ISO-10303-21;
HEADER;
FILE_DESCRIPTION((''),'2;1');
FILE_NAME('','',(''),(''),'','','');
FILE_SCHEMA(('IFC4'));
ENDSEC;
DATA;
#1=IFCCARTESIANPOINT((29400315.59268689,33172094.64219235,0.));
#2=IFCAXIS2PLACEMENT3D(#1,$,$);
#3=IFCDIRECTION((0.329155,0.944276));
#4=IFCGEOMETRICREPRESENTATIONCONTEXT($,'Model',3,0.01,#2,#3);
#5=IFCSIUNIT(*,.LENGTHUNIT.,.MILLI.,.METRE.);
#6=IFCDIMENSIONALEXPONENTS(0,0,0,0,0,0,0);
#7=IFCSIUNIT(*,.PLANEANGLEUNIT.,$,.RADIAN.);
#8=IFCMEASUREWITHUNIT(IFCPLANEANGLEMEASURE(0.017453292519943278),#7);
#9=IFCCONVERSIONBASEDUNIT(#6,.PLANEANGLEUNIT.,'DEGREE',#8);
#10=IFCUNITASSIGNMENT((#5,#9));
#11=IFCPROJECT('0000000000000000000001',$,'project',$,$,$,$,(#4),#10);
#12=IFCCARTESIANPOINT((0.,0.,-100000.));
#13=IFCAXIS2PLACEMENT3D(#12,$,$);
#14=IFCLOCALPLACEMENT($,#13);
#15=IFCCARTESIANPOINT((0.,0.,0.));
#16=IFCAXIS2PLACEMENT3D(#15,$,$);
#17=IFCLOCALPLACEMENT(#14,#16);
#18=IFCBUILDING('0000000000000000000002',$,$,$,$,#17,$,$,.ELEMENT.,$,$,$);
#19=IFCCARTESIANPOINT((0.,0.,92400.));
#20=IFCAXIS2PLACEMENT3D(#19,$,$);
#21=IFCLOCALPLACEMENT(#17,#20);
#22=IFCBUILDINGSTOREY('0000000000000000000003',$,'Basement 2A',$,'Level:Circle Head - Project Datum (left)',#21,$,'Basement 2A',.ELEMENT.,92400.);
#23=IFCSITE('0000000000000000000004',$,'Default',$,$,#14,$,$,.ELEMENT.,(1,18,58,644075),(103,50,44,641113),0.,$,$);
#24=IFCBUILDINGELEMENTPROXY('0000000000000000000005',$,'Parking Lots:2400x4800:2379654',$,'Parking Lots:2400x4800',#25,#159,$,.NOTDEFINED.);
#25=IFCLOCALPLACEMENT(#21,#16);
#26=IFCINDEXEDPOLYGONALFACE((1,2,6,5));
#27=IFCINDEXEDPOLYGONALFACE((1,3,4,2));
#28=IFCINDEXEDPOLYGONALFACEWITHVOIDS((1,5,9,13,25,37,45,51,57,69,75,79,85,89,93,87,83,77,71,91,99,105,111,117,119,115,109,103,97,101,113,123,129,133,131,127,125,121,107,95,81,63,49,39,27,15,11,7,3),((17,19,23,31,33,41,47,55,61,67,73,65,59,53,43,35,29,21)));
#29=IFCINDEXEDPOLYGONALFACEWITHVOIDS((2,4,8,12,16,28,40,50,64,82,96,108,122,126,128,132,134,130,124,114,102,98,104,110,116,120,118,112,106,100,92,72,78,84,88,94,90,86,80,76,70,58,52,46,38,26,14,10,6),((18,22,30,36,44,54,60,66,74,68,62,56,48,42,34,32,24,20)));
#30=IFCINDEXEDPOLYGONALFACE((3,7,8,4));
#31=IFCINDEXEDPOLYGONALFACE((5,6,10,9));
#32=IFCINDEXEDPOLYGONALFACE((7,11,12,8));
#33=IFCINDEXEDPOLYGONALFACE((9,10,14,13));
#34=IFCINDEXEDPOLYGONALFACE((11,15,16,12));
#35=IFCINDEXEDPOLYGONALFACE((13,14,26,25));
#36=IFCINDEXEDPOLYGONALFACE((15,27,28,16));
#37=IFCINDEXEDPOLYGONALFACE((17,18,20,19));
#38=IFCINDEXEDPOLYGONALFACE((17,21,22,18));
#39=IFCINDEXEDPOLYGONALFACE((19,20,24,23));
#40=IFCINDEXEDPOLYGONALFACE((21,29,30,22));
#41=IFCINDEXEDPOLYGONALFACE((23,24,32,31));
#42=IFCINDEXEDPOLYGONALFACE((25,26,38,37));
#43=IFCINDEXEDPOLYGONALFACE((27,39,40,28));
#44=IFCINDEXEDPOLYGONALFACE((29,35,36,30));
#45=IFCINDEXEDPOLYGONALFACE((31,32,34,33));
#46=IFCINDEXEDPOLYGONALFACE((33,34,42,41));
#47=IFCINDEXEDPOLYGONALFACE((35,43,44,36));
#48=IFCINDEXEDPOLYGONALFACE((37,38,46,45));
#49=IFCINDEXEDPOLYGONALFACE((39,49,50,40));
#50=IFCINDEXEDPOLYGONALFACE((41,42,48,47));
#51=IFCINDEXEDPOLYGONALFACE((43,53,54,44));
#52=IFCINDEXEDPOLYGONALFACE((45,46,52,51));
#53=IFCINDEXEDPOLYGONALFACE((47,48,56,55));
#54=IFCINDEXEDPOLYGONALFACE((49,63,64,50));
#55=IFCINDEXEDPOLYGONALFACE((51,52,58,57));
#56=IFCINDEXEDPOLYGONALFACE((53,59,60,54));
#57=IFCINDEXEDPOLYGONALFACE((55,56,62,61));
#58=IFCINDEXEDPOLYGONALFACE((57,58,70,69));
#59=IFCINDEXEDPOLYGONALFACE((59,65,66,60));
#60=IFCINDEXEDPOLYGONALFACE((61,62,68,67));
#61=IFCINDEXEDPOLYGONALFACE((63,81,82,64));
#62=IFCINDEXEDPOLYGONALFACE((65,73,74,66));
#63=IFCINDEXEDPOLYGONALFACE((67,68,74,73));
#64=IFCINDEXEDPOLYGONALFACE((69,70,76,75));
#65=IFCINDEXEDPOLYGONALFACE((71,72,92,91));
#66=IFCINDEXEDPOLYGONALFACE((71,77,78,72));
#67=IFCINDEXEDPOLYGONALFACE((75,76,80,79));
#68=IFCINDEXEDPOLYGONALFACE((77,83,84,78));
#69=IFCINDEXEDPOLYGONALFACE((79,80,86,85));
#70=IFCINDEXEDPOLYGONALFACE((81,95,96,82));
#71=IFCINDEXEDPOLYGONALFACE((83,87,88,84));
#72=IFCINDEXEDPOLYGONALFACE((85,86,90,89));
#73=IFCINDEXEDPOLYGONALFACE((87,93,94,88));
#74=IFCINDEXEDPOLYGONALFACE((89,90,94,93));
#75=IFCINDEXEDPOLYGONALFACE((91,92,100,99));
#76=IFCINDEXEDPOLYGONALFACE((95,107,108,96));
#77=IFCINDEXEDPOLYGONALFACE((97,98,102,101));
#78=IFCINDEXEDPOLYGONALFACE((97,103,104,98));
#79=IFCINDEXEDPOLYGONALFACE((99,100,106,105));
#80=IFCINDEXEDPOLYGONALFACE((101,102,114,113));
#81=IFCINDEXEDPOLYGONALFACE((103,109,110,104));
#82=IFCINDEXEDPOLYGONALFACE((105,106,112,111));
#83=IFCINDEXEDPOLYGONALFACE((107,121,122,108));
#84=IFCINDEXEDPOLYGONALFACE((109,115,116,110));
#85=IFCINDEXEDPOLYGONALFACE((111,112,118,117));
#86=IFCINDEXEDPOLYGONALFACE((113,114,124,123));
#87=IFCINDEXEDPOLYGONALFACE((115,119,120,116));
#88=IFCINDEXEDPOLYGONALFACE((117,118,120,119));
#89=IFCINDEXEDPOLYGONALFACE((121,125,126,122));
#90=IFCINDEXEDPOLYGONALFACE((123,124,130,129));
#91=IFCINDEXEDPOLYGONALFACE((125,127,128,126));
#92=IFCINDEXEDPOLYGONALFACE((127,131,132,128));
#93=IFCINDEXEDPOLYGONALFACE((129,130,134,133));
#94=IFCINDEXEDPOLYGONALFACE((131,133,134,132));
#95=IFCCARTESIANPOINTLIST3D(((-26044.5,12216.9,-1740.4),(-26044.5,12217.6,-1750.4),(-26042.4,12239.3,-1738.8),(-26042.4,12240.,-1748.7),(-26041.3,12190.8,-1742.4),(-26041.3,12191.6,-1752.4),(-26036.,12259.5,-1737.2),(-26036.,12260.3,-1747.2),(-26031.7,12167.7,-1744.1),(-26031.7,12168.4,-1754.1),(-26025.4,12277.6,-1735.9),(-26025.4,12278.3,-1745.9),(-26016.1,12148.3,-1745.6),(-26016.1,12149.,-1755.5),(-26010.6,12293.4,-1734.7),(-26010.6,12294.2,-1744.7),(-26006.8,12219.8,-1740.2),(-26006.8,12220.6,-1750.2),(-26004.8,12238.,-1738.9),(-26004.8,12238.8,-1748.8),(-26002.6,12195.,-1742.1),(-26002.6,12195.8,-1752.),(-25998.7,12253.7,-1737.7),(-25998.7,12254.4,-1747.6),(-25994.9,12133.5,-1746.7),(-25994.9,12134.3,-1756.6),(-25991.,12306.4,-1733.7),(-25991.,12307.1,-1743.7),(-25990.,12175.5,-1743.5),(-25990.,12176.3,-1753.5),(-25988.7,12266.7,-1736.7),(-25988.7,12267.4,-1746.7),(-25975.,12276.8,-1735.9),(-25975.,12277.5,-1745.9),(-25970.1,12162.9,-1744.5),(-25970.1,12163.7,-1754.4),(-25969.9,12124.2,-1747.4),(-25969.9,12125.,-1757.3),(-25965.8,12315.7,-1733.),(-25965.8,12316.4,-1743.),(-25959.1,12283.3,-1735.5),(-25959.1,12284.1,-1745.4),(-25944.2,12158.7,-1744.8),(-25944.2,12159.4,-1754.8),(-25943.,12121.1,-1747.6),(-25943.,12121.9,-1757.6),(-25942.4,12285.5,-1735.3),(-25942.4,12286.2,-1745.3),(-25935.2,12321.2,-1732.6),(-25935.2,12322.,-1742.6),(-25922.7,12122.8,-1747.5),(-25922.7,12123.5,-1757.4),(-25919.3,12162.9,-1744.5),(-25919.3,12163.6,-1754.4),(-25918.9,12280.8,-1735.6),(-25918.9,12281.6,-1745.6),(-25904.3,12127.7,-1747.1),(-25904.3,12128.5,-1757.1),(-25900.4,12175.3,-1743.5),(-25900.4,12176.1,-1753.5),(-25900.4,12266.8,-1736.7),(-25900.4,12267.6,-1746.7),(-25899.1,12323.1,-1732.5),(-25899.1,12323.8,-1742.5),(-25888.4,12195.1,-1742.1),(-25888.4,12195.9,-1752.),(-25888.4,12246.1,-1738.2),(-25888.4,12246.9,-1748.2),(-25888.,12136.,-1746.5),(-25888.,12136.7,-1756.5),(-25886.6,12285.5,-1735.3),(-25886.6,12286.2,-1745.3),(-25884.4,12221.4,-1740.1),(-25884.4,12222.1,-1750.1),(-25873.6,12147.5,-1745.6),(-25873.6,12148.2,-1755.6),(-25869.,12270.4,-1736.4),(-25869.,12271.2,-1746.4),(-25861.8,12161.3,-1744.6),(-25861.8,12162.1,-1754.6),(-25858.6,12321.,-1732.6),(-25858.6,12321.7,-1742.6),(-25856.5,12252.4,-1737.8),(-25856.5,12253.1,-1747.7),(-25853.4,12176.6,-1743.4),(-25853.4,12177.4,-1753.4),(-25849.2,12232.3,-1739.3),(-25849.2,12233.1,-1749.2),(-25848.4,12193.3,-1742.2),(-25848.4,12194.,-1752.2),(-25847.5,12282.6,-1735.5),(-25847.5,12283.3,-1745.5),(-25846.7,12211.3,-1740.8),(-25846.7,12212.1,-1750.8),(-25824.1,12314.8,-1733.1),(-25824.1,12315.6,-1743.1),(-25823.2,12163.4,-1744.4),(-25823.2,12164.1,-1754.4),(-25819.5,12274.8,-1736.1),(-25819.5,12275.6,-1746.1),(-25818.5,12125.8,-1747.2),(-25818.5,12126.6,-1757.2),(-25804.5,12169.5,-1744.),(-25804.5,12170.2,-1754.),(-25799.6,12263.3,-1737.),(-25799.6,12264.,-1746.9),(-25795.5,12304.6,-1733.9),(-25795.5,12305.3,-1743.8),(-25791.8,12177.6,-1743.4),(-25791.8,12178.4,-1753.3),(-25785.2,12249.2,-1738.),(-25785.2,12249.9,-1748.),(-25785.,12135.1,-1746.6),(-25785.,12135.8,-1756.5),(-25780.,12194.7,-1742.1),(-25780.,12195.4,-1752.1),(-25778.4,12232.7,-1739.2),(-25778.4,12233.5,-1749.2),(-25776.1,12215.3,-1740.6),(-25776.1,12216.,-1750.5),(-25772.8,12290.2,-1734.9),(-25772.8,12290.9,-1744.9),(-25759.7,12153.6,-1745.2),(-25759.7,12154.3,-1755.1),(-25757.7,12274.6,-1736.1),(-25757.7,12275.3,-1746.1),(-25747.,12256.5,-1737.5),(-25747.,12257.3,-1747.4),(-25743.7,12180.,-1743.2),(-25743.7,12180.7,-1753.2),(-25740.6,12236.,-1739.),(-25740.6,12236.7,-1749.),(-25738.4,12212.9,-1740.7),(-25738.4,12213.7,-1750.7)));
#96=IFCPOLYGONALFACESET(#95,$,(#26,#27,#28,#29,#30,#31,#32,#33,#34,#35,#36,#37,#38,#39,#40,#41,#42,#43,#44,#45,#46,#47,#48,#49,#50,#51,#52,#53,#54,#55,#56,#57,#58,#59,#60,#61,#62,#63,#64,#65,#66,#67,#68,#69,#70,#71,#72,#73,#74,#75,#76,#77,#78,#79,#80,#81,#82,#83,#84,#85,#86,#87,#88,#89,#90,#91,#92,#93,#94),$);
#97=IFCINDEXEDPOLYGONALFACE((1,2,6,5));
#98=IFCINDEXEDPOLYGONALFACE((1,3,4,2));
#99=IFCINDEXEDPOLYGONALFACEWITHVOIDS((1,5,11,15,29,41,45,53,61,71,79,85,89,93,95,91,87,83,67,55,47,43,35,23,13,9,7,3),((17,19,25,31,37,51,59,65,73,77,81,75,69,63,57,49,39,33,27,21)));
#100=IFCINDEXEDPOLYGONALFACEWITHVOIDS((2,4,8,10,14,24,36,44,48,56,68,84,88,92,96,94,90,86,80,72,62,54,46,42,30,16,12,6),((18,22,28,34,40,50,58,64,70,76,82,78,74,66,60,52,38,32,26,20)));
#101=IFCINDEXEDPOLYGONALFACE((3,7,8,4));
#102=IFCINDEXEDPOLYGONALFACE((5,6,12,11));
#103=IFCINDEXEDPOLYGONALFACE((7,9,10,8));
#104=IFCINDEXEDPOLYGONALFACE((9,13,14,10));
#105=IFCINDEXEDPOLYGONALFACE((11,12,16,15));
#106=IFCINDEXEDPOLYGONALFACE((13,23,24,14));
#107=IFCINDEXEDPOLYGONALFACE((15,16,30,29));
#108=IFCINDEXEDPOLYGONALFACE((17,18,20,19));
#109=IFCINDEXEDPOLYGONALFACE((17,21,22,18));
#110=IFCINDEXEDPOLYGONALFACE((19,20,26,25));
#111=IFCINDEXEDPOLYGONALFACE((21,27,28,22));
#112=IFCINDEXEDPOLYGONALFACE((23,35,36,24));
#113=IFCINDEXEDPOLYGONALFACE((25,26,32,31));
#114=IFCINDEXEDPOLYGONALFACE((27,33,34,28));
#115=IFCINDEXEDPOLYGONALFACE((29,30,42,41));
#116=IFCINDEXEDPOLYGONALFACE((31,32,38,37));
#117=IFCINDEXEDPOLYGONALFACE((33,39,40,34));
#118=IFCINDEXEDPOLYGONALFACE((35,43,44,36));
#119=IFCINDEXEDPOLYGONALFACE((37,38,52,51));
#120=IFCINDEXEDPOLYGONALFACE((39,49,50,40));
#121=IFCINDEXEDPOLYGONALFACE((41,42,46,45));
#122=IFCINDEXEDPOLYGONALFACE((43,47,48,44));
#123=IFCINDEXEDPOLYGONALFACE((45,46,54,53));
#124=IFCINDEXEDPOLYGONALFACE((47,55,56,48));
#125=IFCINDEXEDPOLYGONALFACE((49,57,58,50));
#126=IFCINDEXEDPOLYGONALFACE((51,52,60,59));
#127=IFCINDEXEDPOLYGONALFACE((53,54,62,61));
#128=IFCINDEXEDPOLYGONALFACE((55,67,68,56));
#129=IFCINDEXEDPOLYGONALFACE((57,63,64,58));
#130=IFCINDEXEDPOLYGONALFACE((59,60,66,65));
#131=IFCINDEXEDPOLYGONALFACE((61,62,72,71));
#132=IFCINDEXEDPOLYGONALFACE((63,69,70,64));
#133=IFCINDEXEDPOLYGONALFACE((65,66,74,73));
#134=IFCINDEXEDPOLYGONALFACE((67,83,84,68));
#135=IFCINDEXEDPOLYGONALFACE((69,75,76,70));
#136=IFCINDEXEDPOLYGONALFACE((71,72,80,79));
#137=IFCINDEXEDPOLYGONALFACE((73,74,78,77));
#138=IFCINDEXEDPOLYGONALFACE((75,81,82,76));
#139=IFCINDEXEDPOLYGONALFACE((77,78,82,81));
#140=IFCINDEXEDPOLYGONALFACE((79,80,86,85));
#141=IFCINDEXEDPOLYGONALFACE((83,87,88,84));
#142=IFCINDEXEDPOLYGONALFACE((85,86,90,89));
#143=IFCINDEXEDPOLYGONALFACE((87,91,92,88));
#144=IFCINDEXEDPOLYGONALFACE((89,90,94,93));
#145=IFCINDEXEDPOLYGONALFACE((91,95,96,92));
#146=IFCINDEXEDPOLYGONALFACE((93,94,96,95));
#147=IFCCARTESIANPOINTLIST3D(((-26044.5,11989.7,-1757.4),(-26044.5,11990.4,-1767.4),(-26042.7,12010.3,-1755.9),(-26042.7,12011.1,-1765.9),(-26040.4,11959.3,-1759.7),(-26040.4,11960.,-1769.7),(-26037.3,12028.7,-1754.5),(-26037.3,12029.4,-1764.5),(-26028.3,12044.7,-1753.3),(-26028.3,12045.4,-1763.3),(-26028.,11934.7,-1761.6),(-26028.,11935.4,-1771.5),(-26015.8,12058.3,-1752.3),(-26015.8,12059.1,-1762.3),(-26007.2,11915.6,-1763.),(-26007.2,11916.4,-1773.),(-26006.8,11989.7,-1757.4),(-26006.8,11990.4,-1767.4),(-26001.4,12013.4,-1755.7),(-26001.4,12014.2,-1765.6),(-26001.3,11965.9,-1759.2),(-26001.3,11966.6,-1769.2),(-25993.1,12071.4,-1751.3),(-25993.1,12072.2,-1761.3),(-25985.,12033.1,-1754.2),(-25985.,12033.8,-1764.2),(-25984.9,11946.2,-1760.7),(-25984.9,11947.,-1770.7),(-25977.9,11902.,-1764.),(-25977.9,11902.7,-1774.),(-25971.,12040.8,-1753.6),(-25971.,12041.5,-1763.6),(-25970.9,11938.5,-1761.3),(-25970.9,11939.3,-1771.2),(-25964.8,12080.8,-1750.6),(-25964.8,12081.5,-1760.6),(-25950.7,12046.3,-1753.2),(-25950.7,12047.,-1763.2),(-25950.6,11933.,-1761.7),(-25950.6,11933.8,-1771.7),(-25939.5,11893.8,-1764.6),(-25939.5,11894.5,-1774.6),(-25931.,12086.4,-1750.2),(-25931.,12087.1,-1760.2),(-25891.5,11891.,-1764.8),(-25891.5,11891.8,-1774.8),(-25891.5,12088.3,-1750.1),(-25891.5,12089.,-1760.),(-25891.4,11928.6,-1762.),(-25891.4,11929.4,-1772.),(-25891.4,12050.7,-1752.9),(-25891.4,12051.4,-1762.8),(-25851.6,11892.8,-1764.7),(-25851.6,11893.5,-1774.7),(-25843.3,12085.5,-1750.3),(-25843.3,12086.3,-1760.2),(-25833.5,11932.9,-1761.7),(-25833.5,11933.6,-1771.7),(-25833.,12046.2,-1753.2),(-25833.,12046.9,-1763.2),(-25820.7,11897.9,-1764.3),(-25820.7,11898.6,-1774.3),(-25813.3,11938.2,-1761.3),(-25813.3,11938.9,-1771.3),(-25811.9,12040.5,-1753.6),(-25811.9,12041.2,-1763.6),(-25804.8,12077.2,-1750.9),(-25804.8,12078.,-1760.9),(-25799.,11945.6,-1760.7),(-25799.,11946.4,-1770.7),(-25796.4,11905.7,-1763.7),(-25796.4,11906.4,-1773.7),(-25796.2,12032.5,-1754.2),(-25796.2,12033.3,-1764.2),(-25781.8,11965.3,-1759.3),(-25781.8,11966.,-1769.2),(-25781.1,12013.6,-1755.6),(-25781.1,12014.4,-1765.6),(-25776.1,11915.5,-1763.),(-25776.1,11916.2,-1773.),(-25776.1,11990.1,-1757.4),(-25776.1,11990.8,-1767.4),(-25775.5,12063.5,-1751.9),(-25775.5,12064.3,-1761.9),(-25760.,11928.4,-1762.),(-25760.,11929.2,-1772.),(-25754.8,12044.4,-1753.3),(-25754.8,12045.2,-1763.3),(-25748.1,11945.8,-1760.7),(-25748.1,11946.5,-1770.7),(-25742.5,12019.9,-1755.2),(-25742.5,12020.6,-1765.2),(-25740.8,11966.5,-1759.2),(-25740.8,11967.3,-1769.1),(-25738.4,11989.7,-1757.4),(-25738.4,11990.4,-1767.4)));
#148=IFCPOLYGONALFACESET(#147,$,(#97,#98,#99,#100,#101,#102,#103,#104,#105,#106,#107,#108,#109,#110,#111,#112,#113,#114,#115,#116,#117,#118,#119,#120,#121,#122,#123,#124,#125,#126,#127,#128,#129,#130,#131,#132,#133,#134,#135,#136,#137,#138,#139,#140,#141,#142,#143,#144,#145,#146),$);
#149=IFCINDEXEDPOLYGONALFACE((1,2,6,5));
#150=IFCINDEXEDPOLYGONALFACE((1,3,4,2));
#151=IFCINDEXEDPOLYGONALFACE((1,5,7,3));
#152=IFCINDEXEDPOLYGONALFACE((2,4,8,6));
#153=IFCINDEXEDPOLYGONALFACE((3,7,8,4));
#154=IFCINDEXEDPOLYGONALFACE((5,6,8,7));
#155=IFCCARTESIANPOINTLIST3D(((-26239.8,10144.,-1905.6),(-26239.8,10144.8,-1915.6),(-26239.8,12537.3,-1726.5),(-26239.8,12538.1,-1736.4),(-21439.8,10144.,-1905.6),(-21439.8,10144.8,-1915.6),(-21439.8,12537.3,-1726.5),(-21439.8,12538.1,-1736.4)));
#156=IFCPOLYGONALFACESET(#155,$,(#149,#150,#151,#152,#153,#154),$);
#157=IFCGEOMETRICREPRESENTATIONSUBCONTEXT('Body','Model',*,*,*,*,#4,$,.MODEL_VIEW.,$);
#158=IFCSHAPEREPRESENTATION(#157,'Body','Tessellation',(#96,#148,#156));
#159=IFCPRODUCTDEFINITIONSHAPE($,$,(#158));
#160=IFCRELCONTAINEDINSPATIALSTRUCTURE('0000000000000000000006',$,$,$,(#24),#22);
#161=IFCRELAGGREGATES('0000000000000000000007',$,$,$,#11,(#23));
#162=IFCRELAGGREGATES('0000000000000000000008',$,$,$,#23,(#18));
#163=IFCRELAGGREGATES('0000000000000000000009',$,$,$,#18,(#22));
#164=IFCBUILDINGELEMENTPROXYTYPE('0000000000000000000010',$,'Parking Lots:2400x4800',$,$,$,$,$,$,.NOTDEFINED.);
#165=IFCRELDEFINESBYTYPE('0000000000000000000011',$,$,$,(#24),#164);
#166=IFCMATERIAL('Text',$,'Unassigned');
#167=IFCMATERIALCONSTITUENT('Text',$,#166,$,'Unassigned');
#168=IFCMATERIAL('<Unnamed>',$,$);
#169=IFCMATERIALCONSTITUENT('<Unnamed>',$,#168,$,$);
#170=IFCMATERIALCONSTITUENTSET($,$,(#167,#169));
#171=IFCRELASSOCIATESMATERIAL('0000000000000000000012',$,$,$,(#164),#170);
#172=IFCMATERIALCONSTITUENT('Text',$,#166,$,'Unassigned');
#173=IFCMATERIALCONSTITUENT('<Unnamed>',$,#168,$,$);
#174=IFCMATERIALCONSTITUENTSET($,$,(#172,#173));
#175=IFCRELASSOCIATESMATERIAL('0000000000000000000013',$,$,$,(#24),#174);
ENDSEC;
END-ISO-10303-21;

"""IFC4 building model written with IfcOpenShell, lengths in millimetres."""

from ifc_helpers import new_model, entity, si_unit, converted_unit, direction, frame, origin, place, context, subcontext, project, spatial, indexed_curve, outline, extrude, source, transform, mapped, material, constituent, constituent_set, type_object, type_shapes, element, save


model = new_model("IFC4")

# Units and contexts
model_context = context("Model", 3, precision=0.01, world=frame((29400315.59268689, 33172094.64219235, 0.0)), true_north=direction((0.329155, 0.944276)))
body_context = subcontext(model_context, "Body", "Model", "MODEL_VIEW")
ifc_project = project(units=[si_unit("LENGTHUNIT", "METRE", prefix="MILLI"), converted_unit("PLANEANGLEUNIT", "DEGREE", entity("IfcPlaneAngleMeasure", 0.017453292519943278), si_unit("PLANEANGLEUNIT", "RADIAN"), dimensions=[0, 0, 0, 0, 0, 0, 0])], contexts=[model_context])

# Site, building, storey
site_placement = place(None, frame((0.0, 0.0, -100000.0)))
site = spatial("IfcSite", under=ifc_project, at=site_placement, Name="Default", CompositionType="ELEMENT", RefLatitude=(1, 18, 58, 644075), RefLongitude=(103, 50, 44, 641113), RefElevation=0.0)
building_placement = place(site_placement, origin())
building = spatial("IfcBuilding", under=site, at=building_placement, CompositionType="ELEMENT")
storey_placement = place(building_placement, frame((0.0, 0.0, 92400.0)))
storey = spatial("IfcBuildingStorey", under=building, at=storey_placement, Name="Basement 2A", ObjectType="Level:Circle Head - Project Datum (left)", LongName="Basement 2A", CompositionType="ELEMENT", Elevation=92400.0)

# Building element proxy
ifc_material_1 = material(Name="Text", Category="Unassigned")
ifc_material_2 = material(Name="<Unnamed>")
ifc_constituent_1 = constituent(ifc_material_1, Name="Text", Category="Unassigned")
ifc_constituent_2 = constituent(ifc_material_2, Name="<Unnamed>")
ifc_constituent_set_1 = constituent_set(constituents=[ifc_constituent_1, ifc_constituent_2])
ifc_constituent_3 = constituent(ifc_material_1, Name="Text", Category="Unassigned")
ifc_constituent_4 = constituent(ifc_material_2, Name="<Unnamed>")
ifc_constituent_set_2 = constituent_set(constituents=[ifc_constituent_3, ifc_constituent_4])
building_element_proxy_type_1 = type_object("IfcBuildingElementProxyType", Name="Parking Lots:2400x4800", PredefinedType="NOTDEFINED", material=ifc_constituent_set_2)
shared_shape_1 = source(origin(), body_context, "Body", "SweptSolid", [
    extrude(outline(indexed_curve([(26.9, -105.5), (61.6, -105.5), (91.0, -94.4), (113.4, -73.2), (127.3, -42.7), (131.4, -19.9), (130.7, 1.7), (125.2, 22.0), (114.9, 41.1), (96.9, 61.1), (72.1, 78.6), (40.4, 93.8), (2.0, 106.6), (-33.3, 114.5), (-64.3, 117.3), (-91.0, 115.0), (-113.4, 107.8), (-132.0, 96.4), (-147.0, 81.8), (-158.5, 63.9), (-166.6, 42.8), (-170.5, 16.8), (-167.4, -8.2), (-157.6, -31.1), (-141.1, -50.9), (-119.5, -66.6), (-94.3, -76.8), (-74.4, -80.6), (-55.4, -80.8), (-37.4, -77.2), (-20.4, -69.9), (-5.4, -59.6), (6.8, -47.1), (16.1, -32.4), (22.5, -15.4), (25.8, 5.6), (24.1, 26.9), (16.9, 47.7), (4.0, 67.0), (40.9, 53.7), (65.8, 38.7), (81.8, 22.3), (92.0, 4.8), (94.1, -12.9), (91.7, -30.4), (82.4, -49.3), (66.5, -62.6), (52.0, -67.1), (32.4, -68.0), (26.9, -105.5)], self_intersect=False), holes=[indexed_curve([(-49.8, 81.9), (-28.4, 71.1), (-14.3, 52.6), (-8.3, 29.4), (-11.1, 4.4), (-21.9, -19.9), (-38.8, -35.8), (-60.4, -42.8), (-85.5, -40.2), (-109.3, -29.2), (-125.1, -11.7), (-132.0, 10.5), (-129.5, 35.6), (-122.6, 52.6), (-112.6, 66.2), (-99.5, 76.0), (-83.5, 82.2), (-66.4, 84.2), (-49.8, 81.9)], self_intersect=False)]), frame((317.4, -4432.8, 10.0), z_axis=(0.0, 0.0, 1.0), x_axis=(-0.267015, 0.963692, 0.0)), (0.0, 0.0, 1.0), 10.0),
    extrude(outline(indexed_curve([(-5.6, -99.5), (33.9, -99.5), (68.0, -95.5), (96.7, -87.5), (120.0, -75.5), (133.2, -62.4), (142.9, -46.8), (149.1, -28.7), (151.9, -8.0), (149.2, 22.6), (138.0, 47.8), (118.2, 67.9), (89.5, 82.9), (51.6, 93.0), (3.8, 98.0), (-36.2, 98.2), (-67.3, 94.5), (-91.9, 87.9), (-112.6, 79.0), (-129.4, 66.8), (-142.0, 50.0), (-150.3, 29.6), (-153.8, 6.5), (-151.2, -23.9), (-140.1, -49.1), (-120.3, -69.2), (-91.7, -84.4), (-53.6, -94.5), (-5.6, -99.5)], self_intersect=False), holes=[indexed_curve([(-3.9, -61.9), (-62.1, -54.6), (-82.9, -47.9), (-98.1, -39.2), (-112.3, -19.5), (-116.2, 4.3), (-109.3, 28.9), (-91.2, 47.7), (-76.5, 54.5), (-56.1, 58.9), (1.9, 60.4), (60.8, 53.2), (80.8, 46.7), (94.5, 38.3), (109.9, 17.8), (114.3, -6.3), (107.7, -29.8), (90.4, -48.7), (76.0, -55.8), (55.5, -60.3), (-3.9, -61.9)], self_intersect=False)]), frame((549.3, -4452.6, 10.0), z_axis=(0.0, 0.0, 1.0), x_axis=(0.047515, -0.998871, 0.0)), (0.0, 0.0, 1.0), 10.0),
    extrude(outline(indexed_curve([(-1200.0, -2400.0), (1200.0, -2400.0), (1200.0, 2400.0), (-1200.0, 2400.0), (-1200.0, -2400.0)], self_intersect=False)), frame((1200.0, -2400.0, 0.0), z_axis=(0.0, 0.0, 1.0), x_axis=(-1.0, 0.0, 0.0)), (0.0, 0.0, 1.0), 10.0),
])
type_shapes(building_element_proxy_type_1, [shared_shape_1])
proxy_1_placement = place(storey_placement, frame((-21439.8, 12538.1, -1736.4), z_axis=(0.0, -0.074648, 0.99721), x_axis=(0.0, -0.99721, -0.074648)))
element("IfcBuildingElementProxy", 1, at=proxy_1_placement, inside=storey, type_object=building_element_proxy_type_1, material=ifc_constituent_set_1, Name="Parking Lots:2400x4800:2379654", ObjectType="Parking Lots:2400x4800", PredefinedType="NOTDEFINED", context=body_context, shape_type="MappedRepresentation", body=[
    mapped(shared_shape_1, transform((0.0, 0.0, 0.0), scale=1.0)),
])

save(model, "model.ifc")
